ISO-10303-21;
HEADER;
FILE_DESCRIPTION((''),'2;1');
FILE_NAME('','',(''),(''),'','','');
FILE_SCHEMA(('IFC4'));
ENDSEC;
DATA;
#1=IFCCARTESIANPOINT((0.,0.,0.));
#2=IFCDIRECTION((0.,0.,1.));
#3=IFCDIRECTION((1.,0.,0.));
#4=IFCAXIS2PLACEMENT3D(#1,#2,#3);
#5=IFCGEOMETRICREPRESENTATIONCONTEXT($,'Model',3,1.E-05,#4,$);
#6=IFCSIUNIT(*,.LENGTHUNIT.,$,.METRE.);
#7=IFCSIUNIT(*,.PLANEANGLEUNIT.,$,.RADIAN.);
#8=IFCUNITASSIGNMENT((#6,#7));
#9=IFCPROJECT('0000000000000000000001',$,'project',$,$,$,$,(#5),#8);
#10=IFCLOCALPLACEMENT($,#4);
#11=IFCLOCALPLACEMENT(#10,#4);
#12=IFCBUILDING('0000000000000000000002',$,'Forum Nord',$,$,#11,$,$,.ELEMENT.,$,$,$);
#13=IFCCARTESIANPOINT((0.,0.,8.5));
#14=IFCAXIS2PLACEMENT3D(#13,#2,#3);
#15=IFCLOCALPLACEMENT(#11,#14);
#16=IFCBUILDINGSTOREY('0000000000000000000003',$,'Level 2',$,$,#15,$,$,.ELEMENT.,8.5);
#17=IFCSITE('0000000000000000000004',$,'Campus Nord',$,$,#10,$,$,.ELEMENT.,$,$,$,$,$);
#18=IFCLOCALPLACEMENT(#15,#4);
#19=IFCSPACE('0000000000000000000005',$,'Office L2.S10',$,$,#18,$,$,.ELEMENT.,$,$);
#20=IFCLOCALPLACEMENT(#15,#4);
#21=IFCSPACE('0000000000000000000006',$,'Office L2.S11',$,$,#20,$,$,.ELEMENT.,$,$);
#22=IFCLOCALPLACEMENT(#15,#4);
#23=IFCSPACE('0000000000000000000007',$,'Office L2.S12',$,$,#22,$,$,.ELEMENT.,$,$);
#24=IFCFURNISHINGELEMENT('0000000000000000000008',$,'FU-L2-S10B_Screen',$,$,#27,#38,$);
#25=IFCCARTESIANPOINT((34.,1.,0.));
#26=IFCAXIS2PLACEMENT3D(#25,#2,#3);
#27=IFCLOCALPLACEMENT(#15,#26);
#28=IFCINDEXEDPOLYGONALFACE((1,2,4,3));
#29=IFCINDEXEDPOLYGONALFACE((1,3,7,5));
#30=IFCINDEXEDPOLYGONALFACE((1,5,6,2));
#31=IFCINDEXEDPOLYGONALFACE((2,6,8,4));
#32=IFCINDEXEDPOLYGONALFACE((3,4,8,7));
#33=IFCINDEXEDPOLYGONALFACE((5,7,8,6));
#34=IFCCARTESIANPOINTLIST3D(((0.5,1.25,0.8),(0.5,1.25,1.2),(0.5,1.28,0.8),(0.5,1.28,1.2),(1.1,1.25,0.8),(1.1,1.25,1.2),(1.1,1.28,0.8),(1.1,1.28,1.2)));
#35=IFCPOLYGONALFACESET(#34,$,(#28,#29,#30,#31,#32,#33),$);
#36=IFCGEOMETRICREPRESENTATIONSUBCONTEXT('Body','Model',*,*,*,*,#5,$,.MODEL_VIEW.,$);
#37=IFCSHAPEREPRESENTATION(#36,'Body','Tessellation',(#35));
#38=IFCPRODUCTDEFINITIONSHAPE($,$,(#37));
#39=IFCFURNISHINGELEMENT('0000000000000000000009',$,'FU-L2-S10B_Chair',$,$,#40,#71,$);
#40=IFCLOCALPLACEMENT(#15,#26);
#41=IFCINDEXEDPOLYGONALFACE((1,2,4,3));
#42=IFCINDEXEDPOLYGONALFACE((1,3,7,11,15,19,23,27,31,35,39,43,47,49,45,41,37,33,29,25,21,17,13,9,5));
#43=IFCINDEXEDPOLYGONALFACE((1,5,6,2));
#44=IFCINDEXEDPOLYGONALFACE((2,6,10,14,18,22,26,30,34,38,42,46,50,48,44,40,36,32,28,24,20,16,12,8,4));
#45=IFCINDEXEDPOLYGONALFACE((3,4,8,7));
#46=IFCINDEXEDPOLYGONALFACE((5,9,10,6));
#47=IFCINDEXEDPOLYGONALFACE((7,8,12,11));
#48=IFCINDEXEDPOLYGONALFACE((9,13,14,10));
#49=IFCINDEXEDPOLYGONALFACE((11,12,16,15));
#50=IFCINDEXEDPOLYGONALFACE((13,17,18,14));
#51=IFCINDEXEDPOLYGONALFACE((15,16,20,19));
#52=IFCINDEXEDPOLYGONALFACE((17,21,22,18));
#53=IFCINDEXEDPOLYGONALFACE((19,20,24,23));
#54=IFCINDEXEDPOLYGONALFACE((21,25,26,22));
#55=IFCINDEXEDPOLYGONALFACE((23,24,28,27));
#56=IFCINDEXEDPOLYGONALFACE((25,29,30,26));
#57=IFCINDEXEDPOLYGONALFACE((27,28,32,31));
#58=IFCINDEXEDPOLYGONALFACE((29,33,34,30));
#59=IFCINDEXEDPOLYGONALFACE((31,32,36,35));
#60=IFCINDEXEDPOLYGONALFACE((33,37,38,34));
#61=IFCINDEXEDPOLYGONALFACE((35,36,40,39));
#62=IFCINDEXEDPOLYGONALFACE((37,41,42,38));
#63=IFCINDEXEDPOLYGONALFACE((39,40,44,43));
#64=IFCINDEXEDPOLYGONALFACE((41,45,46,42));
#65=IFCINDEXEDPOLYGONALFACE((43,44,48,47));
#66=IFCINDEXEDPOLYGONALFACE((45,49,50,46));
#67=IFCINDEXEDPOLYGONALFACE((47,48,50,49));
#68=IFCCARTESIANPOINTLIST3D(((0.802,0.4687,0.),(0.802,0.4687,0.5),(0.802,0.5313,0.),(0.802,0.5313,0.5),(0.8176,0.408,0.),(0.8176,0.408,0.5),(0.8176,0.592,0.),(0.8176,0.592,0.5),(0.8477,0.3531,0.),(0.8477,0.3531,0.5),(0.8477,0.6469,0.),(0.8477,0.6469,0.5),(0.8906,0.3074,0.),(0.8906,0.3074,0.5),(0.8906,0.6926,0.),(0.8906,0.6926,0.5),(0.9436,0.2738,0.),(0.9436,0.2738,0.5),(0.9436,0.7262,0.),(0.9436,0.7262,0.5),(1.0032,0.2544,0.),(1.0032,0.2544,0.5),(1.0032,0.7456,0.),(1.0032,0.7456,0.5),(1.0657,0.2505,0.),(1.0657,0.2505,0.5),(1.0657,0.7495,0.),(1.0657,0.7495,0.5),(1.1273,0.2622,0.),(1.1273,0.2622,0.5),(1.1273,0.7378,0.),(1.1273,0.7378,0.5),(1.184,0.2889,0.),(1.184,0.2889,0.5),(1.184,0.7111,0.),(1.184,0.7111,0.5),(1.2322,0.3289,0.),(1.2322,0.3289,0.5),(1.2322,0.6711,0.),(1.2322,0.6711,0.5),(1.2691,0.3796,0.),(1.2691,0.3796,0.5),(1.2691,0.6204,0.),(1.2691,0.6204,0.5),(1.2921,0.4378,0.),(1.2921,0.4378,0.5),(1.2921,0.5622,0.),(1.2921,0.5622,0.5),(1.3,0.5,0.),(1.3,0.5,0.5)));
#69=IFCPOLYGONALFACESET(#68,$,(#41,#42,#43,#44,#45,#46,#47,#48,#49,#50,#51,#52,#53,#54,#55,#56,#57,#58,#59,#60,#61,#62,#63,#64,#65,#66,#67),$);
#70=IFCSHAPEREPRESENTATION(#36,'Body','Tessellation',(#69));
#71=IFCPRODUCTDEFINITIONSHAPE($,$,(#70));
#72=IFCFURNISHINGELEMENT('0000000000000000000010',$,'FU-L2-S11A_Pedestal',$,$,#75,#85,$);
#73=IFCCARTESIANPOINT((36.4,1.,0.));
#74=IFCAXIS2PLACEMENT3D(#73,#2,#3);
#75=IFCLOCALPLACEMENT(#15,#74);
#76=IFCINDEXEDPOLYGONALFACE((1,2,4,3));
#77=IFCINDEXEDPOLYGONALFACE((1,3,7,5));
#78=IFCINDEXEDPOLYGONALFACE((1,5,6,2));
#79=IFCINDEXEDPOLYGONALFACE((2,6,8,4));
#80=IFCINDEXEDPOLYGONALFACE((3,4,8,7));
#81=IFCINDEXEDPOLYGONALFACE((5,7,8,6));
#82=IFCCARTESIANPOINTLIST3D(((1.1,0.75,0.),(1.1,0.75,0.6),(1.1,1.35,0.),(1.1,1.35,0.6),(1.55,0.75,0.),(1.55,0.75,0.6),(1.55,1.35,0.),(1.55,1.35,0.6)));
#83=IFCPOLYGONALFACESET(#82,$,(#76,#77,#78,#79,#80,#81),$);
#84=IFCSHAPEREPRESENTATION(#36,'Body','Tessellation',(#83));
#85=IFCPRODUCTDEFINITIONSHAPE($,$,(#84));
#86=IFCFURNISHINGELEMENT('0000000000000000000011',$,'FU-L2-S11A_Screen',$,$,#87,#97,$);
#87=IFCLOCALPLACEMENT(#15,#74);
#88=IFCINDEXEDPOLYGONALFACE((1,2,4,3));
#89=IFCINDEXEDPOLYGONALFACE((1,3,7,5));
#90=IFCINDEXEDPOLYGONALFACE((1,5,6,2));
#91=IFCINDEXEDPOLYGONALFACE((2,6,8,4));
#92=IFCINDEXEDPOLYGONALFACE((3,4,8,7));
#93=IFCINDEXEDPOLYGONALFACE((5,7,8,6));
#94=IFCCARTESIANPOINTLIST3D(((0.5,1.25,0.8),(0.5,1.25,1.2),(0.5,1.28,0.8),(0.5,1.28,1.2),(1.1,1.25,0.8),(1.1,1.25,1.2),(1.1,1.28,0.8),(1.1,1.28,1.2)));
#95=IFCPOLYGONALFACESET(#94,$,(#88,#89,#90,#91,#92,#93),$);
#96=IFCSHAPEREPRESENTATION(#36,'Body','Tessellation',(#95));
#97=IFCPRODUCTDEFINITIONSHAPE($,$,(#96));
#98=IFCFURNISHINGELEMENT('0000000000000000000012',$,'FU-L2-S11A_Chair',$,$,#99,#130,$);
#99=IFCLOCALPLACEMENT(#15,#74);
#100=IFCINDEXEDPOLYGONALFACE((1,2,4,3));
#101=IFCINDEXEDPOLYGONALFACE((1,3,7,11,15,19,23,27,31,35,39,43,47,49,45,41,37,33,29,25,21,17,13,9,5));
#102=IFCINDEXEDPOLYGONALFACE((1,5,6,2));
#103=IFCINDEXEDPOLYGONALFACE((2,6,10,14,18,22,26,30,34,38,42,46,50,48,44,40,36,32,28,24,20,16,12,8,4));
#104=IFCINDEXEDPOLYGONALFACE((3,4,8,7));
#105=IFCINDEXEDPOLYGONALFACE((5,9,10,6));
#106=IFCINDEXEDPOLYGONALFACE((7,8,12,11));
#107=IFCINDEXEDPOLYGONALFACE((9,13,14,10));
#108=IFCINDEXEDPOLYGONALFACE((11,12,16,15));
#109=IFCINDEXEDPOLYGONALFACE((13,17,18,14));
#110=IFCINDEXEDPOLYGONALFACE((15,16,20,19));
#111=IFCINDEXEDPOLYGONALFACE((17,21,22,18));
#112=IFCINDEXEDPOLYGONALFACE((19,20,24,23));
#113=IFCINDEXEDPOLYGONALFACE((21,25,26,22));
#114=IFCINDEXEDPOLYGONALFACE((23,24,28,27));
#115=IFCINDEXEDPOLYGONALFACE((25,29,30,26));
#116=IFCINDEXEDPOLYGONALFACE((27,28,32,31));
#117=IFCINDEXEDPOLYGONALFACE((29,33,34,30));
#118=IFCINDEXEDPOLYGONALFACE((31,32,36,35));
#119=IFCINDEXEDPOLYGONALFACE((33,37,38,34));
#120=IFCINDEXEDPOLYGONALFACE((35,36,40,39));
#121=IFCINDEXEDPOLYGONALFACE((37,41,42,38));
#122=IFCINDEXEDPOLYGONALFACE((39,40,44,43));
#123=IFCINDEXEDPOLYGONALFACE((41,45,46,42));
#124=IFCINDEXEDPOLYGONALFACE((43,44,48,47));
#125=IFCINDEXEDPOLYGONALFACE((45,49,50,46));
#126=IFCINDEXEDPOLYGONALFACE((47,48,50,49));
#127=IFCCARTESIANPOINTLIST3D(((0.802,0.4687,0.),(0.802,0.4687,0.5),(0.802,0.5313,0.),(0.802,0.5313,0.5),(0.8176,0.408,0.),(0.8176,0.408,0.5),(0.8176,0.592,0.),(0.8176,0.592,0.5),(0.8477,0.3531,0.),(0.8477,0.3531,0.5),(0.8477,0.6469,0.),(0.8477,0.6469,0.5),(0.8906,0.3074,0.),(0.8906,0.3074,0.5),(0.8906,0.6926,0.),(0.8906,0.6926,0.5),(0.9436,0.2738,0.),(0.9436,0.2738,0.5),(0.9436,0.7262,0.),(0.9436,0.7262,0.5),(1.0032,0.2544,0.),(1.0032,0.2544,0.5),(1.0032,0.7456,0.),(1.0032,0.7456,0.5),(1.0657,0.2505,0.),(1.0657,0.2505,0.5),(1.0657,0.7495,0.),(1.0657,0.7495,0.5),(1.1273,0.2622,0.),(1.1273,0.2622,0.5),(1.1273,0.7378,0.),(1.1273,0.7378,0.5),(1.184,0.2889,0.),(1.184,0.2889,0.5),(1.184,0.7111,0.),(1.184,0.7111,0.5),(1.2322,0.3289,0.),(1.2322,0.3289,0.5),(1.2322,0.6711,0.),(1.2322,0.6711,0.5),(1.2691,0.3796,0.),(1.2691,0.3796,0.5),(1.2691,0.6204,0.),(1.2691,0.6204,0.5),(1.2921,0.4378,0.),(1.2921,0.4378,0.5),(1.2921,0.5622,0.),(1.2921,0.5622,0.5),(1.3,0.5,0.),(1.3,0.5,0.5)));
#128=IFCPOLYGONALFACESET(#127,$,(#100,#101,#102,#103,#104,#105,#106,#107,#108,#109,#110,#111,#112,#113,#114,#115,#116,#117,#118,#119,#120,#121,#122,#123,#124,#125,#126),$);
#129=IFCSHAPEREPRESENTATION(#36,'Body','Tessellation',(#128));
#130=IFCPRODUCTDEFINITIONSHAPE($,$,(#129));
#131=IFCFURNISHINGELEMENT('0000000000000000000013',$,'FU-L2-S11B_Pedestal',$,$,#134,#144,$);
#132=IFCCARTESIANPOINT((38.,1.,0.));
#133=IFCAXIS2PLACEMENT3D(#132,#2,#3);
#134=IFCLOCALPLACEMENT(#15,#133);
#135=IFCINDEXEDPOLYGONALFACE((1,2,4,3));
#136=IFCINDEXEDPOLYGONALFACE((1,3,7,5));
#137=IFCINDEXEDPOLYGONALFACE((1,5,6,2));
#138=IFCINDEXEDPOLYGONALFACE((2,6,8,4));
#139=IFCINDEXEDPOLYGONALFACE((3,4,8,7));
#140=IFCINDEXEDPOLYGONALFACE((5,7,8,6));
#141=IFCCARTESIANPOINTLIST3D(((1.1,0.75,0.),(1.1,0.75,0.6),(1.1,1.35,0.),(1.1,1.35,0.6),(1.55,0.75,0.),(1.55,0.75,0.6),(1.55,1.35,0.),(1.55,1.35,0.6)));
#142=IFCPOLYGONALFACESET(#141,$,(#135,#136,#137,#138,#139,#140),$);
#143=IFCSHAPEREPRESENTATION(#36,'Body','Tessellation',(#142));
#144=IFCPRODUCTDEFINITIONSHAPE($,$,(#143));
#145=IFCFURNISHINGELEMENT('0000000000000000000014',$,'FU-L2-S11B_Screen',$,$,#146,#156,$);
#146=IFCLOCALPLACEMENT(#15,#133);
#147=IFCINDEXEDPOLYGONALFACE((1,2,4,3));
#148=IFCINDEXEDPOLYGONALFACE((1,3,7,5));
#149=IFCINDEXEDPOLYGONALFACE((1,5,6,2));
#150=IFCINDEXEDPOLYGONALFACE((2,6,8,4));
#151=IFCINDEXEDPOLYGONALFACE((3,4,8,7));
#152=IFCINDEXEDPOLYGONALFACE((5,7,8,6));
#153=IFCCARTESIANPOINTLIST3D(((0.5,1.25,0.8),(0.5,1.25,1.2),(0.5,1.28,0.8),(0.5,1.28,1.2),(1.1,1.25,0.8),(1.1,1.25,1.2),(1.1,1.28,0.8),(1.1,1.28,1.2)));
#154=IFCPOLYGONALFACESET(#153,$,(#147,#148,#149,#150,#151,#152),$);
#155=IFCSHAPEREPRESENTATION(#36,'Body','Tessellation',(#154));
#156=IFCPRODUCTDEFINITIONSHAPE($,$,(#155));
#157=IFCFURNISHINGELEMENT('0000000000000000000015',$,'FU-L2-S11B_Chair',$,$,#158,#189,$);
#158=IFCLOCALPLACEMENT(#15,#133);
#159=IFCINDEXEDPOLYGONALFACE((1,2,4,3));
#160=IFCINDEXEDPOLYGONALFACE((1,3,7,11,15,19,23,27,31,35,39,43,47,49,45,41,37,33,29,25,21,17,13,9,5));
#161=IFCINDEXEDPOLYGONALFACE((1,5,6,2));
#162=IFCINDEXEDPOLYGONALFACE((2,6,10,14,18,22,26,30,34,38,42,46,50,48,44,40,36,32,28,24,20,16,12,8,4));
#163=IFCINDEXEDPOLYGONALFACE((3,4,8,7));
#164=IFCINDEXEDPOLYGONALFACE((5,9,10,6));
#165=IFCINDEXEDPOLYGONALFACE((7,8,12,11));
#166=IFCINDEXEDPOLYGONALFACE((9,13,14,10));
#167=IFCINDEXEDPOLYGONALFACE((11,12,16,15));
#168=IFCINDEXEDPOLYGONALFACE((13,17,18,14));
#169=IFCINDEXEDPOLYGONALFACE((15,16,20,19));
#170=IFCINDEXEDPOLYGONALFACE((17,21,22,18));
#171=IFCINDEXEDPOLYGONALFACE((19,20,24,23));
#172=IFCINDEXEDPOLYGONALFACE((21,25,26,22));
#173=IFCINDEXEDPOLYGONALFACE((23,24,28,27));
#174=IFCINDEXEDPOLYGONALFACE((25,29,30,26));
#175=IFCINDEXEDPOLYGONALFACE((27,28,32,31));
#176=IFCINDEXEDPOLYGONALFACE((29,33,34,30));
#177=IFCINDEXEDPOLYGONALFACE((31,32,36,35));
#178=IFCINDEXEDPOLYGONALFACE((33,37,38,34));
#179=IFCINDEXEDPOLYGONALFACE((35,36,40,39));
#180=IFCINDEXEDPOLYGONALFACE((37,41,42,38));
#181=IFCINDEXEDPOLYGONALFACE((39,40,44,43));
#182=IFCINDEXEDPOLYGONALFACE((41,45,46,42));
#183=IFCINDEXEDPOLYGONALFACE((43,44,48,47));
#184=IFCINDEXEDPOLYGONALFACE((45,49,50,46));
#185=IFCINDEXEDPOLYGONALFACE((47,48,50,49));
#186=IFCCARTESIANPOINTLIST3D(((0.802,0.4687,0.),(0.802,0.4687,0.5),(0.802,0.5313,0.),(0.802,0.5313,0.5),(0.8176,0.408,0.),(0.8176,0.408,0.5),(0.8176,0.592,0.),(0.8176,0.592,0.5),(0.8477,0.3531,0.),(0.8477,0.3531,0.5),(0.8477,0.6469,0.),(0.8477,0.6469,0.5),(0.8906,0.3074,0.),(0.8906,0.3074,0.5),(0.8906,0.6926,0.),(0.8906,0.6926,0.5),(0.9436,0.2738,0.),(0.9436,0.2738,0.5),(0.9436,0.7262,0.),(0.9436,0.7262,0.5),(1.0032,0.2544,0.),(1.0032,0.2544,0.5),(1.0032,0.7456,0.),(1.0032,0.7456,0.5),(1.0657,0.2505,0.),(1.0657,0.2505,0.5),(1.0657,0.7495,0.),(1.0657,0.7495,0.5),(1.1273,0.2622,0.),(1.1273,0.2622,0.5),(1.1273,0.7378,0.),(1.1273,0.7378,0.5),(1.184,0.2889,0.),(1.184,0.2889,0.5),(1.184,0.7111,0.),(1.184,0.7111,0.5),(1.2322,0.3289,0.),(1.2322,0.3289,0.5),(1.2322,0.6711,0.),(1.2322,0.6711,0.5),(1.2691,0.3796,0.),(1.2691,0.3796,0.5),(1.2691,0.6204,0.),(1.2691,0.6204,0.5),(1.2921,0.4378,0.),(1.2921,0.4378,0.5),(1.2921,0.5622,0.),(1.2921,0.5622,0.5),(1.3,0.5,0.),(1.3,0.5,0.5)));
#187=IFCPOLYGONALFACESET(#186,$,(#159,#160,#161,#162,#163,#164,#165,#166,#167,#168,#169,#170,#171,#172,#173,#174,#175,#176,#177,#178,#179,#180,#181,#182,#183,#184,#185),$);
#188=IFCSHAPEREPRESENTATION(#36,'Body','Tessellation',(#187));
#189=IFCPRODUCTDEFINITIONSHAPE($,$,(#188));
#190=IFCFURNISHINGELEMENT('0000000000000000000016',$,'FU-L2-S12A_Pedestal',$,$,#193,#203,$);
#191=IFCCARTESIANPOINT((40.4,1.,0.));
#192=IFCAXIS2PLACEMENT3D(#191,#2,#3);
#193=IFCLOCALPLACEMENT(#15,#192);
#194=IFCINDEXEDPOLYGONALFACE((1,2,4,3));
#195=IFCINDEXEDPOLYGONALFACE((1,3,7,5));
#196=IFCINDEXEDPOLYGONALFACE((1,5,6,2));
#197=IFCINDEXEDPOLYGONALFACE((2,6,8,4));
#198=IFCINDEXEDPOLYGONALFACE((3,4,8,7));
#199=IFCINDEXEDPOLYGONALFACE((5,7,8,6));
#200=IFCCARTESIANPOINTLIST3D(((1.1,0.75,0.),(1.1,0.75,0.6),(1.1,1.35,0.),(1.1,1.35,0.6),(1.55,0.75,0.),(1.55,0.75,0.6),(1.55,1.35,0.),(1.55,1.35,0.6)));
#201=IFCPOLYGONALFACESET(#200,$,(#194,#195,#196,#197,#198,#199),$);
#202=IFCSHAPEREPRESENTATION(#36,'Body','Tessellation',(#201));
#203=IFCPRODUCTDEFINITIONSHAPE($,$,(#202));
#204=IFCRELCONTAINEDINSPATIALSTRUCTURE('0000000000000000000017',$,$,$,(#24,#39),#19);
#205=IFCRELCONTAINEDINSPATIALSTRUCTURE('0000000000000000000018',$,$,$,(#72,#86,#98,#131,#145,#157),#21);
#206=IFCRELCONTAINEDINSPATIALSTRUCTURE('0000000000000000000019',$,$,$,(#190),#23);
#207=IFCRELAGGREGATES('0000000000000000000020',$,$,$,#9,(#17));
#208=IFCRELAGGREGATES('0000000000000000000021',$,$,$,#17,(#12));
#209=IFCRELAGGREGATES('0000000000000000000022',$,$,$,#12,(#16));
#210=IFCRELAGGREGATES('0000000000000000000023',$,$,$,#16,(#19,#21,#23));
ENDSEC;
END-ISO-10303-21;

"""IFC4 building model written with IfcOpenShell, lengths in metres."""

from ifc_helpers import new_model, si_unit, frame, frame_2d, origin_with_axes, place, context, subcontext, project, spatial, rectangle, circle, extrude, element, save


model = new_model("IFC4")

# Units and contexts
model_context = context("Model", 3, precision=1e-05, world=origin_with_axes())
body_context = subcontext(model_context, "Body", "Model", "MODEL_VIEW")
ifc_project = project(units=[si_unit("LENGTHUNIT", "METRE"), si_unit("PLANEANGLEUNIT", "RADIAN")], contexts=[model_context])

# Site, building, storey
site_placement = place(None, origin_with_axes())
site = spatial("IfcSite", under=ifc_project, at=site_placement, Name="Campus Nord", CompositionType="ELEMENT")
building_placement = place(site_placement, origin_with_axes())
building = spatial("IfcBuilding", under=site, at=building_placement, Name="Forum Nord", CompositionType="ELEMENT")
storey_placement = place(building_placement, frame((0.0, 0.0, 8.5), z_axis=(0.0, 0.0, 1.0), x_axis=(1.0, 0.0, 0.0)))
storey = spatial("IfcBuildingStorey", under=building, at=storey_placement, Name="Level 2", CompositionType="ELEMENT", Elevation=8.5)

# Shared definitions
space_1_placement = place(storey_placement, origin_with_axes())
space_1 = spatial("IfcSpace", under=storey, at=space_1_placement, Name="Office L2.S10", CompositionType="ELEMENT")

# Furnishing elements
furnishing_1_placement = place(storey_placement, frame((34.0, 1.0, 0.0), z_axis=(0.0, 0.0, 1.0), x_axis=(1.0, 0.0, 0.0)))
element("IfcFurnishingElement", 1, at=furnishing_1_placement, inside=space_1, Name="FU-L2-S10B_Screen", context=body_context, shape_type="SweptSolid", body=[
    extrude(rectangle(XDim=0.6, YDim=0.03, at=frame_2d((0.8, 1.265), x_axis=(1.0, 0.0))), frame((0.0, 0.0, 0.8), z_axis=(0.0, 0.0, 1.0), x_axis=(1.0, 0.0, 0.0)), (0.0, 0.0, 1.0), 0.4),
])
furnishing_2_placement = place(storey_placement, frame((34.0, 1.0, 0.0), z_axis=(0.0, 0.0, 1.0), x_axis=(1.0, 0.0, 0.0)))
element("IfcFurnishingElement", 2, at=furnishing_2_placement, inside=space_1, Name="FU-L2-S10B_Chair", context=body_context, shape_type="SweptSolid", body=[
    extrude(circle(Radius=0.25, at=frame_2d((1.05, 0.5), x_axis=(1.0, 0.0))), origin_with_axes(), (0.0, 0.0, 1.0), 0.5),
])

# Shared definitions
space_2_placement = place(storey_placement, origin_with_axes())
space_2 = spatial("IfcSpace", under=storey, at=space_2_placement, Name="Office L2.S11", CompositionType="ELEMENT")

# Furnishing elements
furnishing_3_placement = place(storey_placement, frame((36.4, 1.0, 0.0), z_axis=(0.0, 0.0, 1.0), x_axis=(1.0, 0.0, 0.0)))
element("IfcFurnishingElement", 3, at=furnishing_3_placement, inside=space_2, Name="FU-L2-S11A_Pedestal", context=body_context, shape_type="SweptSolid", body=[
    extrude(rectangle(XDim=0.45, YDim=0.6, at=frame_2d((1.325, 1.05), x_axis=(1.0, 0.0))), origin_with_axes(), (0.0, 0.0, 1.0), 0.6),
])
furnishing_4_placement = place(storey_placement, frame((36.4, 1.0, 0.0), z_axis=(0.0, 0.0, 1.0), x_axis=(1.0, 0.0, 0.0)))
element("IfcFurnishingElement", 4, at=furnishing_4_placement, inside=space_2, Name="FU-L2-S11A_Screen", context=body_context, shape_type="SweptSolid", body=[
    extrude(rectangle(XDim=0.6, YDim=0.03, at=frame_2d((0.8, 1.265), x_axis=(1.0, 0.0))), frame((0.0, 0.0, 0.8), z_axis=(0.0, 0.0, 1.0), x_axis=(1.0, 0.0, 0.0)), (0.0, 0.0, 1.0), 0.4),
])
furnishing_5_placement = place(storey_placement, frame((36.4, 1.0, 0.0), z_axis=(0.0, 0.0, 1.0), x_axis=(1.0, 0.0, 0.0)))
element("IfcFurnishingElement", 5, at=furnishing_5_placement, inside=space_2, Name="FU-L2-S11A_Chair", context=body_context, shape_type="SweptSolid", body=[
    extrude(circle(Radius=0.25, at=frame_2d((1.05, 0.5), x_axis=(1.0, 0.0))), origin_with_axes(), (0.0, 0.0, 1.0), 0.5),
])
furnishing_6_placement = place(storey_placement, frame((38.0, 1.0, 0.0), z_axis=(0.0, 0.0, 1.0), x_axis=(1.0, 0.0, 0.0)))
element("IfcFurnishingElement", 6, at=furnishing_6_placement, inside=space_2, Name="FU-L2-S11B_Pedestal", context=body_context, shape_type="SweptSolid", body=[
    extrude(rectangle(XDim=0.45, YDim=0.6, at=frame_2d((1.325, 1.05), x_axis=(1.0, 0.0))), origin_with_axes(), (0.0, 0.0, 1.0), 0.6),
])
furnishing_7_placement = place(storey_placement, frame((38.0, 1.0, 0.0), z_axis=(0.0, 0.0, 1.0), x_axis=(1.0, 0.0, 0.0)))
element("IfcFurnishingElement", 7, at=furnishing_7_placement, inside=space_2, Name="FU-L2-S11B_Screen", context=body_context, shape_type="SweptSolid", body=[
    extrude(rectangle(XDim=0.6, YDim=0.03, at=frame_2d((0.8, 1.265), x_axis=(1.0, 0.0))), frame((0.0, 0.0, 0.8), z_axis=(0.0, 0.0, 1.0), x_axis=(1.0, 0.0, 0.0)), (0.0, 0.0, 1.0), 0.4),
])
furnishing_8_placement = place(storey_placement, frame((38.0, 1.0, 0.0), z_axis=(0.0, 0.0, 1.0), x_axis=(1.0, 0.0, 0.0)))
element("IfcFurnishingElement", 8, at=furnishing_8_placement, inside=space_2, Name="FU-L2-S11B_Chair", context=body_context, shape_type="SweptSolid", body=[
    extrude(circle(Radius=0.25, at=frame_2d((1.05, 0.5), x_axis=(1.0, 0.0))), origin_with_axes(), (0.0, 0.0, 1.0), 0.5),
])

# Shared definitions
space_3_placement = place(storey_placement, origin_with_axes())
space_3 = spatial("IfcSpace", under=storey, at=space_3_placement, Name="Office L2.S12", CompositionType="ELEMENT")

# Furnishing element
furnishing_9_placement = place(storey_placement, frame((40.4, 1.0, 0.0), z_axis=(0.0, 0.0, 1.0), x_axis=(1.0, 0.0, 0.0)))
element("IfcFurnishingElement", 9, at=furnishing_9_placement, inside=space_3, Name="FU-L2-S12A_Pedestal", context=body_context, shape_type="SweptSolid", body=[
    extrude(rectangle(XDim=0.45, YDim=0.6, at=frame_2d((1.325, 1.05), x_axis=(1.0, 0.0))), origin_with_axes(), (0.0, 0.0, 1.0), 0.6),
])

save(model, "model.ifc")
